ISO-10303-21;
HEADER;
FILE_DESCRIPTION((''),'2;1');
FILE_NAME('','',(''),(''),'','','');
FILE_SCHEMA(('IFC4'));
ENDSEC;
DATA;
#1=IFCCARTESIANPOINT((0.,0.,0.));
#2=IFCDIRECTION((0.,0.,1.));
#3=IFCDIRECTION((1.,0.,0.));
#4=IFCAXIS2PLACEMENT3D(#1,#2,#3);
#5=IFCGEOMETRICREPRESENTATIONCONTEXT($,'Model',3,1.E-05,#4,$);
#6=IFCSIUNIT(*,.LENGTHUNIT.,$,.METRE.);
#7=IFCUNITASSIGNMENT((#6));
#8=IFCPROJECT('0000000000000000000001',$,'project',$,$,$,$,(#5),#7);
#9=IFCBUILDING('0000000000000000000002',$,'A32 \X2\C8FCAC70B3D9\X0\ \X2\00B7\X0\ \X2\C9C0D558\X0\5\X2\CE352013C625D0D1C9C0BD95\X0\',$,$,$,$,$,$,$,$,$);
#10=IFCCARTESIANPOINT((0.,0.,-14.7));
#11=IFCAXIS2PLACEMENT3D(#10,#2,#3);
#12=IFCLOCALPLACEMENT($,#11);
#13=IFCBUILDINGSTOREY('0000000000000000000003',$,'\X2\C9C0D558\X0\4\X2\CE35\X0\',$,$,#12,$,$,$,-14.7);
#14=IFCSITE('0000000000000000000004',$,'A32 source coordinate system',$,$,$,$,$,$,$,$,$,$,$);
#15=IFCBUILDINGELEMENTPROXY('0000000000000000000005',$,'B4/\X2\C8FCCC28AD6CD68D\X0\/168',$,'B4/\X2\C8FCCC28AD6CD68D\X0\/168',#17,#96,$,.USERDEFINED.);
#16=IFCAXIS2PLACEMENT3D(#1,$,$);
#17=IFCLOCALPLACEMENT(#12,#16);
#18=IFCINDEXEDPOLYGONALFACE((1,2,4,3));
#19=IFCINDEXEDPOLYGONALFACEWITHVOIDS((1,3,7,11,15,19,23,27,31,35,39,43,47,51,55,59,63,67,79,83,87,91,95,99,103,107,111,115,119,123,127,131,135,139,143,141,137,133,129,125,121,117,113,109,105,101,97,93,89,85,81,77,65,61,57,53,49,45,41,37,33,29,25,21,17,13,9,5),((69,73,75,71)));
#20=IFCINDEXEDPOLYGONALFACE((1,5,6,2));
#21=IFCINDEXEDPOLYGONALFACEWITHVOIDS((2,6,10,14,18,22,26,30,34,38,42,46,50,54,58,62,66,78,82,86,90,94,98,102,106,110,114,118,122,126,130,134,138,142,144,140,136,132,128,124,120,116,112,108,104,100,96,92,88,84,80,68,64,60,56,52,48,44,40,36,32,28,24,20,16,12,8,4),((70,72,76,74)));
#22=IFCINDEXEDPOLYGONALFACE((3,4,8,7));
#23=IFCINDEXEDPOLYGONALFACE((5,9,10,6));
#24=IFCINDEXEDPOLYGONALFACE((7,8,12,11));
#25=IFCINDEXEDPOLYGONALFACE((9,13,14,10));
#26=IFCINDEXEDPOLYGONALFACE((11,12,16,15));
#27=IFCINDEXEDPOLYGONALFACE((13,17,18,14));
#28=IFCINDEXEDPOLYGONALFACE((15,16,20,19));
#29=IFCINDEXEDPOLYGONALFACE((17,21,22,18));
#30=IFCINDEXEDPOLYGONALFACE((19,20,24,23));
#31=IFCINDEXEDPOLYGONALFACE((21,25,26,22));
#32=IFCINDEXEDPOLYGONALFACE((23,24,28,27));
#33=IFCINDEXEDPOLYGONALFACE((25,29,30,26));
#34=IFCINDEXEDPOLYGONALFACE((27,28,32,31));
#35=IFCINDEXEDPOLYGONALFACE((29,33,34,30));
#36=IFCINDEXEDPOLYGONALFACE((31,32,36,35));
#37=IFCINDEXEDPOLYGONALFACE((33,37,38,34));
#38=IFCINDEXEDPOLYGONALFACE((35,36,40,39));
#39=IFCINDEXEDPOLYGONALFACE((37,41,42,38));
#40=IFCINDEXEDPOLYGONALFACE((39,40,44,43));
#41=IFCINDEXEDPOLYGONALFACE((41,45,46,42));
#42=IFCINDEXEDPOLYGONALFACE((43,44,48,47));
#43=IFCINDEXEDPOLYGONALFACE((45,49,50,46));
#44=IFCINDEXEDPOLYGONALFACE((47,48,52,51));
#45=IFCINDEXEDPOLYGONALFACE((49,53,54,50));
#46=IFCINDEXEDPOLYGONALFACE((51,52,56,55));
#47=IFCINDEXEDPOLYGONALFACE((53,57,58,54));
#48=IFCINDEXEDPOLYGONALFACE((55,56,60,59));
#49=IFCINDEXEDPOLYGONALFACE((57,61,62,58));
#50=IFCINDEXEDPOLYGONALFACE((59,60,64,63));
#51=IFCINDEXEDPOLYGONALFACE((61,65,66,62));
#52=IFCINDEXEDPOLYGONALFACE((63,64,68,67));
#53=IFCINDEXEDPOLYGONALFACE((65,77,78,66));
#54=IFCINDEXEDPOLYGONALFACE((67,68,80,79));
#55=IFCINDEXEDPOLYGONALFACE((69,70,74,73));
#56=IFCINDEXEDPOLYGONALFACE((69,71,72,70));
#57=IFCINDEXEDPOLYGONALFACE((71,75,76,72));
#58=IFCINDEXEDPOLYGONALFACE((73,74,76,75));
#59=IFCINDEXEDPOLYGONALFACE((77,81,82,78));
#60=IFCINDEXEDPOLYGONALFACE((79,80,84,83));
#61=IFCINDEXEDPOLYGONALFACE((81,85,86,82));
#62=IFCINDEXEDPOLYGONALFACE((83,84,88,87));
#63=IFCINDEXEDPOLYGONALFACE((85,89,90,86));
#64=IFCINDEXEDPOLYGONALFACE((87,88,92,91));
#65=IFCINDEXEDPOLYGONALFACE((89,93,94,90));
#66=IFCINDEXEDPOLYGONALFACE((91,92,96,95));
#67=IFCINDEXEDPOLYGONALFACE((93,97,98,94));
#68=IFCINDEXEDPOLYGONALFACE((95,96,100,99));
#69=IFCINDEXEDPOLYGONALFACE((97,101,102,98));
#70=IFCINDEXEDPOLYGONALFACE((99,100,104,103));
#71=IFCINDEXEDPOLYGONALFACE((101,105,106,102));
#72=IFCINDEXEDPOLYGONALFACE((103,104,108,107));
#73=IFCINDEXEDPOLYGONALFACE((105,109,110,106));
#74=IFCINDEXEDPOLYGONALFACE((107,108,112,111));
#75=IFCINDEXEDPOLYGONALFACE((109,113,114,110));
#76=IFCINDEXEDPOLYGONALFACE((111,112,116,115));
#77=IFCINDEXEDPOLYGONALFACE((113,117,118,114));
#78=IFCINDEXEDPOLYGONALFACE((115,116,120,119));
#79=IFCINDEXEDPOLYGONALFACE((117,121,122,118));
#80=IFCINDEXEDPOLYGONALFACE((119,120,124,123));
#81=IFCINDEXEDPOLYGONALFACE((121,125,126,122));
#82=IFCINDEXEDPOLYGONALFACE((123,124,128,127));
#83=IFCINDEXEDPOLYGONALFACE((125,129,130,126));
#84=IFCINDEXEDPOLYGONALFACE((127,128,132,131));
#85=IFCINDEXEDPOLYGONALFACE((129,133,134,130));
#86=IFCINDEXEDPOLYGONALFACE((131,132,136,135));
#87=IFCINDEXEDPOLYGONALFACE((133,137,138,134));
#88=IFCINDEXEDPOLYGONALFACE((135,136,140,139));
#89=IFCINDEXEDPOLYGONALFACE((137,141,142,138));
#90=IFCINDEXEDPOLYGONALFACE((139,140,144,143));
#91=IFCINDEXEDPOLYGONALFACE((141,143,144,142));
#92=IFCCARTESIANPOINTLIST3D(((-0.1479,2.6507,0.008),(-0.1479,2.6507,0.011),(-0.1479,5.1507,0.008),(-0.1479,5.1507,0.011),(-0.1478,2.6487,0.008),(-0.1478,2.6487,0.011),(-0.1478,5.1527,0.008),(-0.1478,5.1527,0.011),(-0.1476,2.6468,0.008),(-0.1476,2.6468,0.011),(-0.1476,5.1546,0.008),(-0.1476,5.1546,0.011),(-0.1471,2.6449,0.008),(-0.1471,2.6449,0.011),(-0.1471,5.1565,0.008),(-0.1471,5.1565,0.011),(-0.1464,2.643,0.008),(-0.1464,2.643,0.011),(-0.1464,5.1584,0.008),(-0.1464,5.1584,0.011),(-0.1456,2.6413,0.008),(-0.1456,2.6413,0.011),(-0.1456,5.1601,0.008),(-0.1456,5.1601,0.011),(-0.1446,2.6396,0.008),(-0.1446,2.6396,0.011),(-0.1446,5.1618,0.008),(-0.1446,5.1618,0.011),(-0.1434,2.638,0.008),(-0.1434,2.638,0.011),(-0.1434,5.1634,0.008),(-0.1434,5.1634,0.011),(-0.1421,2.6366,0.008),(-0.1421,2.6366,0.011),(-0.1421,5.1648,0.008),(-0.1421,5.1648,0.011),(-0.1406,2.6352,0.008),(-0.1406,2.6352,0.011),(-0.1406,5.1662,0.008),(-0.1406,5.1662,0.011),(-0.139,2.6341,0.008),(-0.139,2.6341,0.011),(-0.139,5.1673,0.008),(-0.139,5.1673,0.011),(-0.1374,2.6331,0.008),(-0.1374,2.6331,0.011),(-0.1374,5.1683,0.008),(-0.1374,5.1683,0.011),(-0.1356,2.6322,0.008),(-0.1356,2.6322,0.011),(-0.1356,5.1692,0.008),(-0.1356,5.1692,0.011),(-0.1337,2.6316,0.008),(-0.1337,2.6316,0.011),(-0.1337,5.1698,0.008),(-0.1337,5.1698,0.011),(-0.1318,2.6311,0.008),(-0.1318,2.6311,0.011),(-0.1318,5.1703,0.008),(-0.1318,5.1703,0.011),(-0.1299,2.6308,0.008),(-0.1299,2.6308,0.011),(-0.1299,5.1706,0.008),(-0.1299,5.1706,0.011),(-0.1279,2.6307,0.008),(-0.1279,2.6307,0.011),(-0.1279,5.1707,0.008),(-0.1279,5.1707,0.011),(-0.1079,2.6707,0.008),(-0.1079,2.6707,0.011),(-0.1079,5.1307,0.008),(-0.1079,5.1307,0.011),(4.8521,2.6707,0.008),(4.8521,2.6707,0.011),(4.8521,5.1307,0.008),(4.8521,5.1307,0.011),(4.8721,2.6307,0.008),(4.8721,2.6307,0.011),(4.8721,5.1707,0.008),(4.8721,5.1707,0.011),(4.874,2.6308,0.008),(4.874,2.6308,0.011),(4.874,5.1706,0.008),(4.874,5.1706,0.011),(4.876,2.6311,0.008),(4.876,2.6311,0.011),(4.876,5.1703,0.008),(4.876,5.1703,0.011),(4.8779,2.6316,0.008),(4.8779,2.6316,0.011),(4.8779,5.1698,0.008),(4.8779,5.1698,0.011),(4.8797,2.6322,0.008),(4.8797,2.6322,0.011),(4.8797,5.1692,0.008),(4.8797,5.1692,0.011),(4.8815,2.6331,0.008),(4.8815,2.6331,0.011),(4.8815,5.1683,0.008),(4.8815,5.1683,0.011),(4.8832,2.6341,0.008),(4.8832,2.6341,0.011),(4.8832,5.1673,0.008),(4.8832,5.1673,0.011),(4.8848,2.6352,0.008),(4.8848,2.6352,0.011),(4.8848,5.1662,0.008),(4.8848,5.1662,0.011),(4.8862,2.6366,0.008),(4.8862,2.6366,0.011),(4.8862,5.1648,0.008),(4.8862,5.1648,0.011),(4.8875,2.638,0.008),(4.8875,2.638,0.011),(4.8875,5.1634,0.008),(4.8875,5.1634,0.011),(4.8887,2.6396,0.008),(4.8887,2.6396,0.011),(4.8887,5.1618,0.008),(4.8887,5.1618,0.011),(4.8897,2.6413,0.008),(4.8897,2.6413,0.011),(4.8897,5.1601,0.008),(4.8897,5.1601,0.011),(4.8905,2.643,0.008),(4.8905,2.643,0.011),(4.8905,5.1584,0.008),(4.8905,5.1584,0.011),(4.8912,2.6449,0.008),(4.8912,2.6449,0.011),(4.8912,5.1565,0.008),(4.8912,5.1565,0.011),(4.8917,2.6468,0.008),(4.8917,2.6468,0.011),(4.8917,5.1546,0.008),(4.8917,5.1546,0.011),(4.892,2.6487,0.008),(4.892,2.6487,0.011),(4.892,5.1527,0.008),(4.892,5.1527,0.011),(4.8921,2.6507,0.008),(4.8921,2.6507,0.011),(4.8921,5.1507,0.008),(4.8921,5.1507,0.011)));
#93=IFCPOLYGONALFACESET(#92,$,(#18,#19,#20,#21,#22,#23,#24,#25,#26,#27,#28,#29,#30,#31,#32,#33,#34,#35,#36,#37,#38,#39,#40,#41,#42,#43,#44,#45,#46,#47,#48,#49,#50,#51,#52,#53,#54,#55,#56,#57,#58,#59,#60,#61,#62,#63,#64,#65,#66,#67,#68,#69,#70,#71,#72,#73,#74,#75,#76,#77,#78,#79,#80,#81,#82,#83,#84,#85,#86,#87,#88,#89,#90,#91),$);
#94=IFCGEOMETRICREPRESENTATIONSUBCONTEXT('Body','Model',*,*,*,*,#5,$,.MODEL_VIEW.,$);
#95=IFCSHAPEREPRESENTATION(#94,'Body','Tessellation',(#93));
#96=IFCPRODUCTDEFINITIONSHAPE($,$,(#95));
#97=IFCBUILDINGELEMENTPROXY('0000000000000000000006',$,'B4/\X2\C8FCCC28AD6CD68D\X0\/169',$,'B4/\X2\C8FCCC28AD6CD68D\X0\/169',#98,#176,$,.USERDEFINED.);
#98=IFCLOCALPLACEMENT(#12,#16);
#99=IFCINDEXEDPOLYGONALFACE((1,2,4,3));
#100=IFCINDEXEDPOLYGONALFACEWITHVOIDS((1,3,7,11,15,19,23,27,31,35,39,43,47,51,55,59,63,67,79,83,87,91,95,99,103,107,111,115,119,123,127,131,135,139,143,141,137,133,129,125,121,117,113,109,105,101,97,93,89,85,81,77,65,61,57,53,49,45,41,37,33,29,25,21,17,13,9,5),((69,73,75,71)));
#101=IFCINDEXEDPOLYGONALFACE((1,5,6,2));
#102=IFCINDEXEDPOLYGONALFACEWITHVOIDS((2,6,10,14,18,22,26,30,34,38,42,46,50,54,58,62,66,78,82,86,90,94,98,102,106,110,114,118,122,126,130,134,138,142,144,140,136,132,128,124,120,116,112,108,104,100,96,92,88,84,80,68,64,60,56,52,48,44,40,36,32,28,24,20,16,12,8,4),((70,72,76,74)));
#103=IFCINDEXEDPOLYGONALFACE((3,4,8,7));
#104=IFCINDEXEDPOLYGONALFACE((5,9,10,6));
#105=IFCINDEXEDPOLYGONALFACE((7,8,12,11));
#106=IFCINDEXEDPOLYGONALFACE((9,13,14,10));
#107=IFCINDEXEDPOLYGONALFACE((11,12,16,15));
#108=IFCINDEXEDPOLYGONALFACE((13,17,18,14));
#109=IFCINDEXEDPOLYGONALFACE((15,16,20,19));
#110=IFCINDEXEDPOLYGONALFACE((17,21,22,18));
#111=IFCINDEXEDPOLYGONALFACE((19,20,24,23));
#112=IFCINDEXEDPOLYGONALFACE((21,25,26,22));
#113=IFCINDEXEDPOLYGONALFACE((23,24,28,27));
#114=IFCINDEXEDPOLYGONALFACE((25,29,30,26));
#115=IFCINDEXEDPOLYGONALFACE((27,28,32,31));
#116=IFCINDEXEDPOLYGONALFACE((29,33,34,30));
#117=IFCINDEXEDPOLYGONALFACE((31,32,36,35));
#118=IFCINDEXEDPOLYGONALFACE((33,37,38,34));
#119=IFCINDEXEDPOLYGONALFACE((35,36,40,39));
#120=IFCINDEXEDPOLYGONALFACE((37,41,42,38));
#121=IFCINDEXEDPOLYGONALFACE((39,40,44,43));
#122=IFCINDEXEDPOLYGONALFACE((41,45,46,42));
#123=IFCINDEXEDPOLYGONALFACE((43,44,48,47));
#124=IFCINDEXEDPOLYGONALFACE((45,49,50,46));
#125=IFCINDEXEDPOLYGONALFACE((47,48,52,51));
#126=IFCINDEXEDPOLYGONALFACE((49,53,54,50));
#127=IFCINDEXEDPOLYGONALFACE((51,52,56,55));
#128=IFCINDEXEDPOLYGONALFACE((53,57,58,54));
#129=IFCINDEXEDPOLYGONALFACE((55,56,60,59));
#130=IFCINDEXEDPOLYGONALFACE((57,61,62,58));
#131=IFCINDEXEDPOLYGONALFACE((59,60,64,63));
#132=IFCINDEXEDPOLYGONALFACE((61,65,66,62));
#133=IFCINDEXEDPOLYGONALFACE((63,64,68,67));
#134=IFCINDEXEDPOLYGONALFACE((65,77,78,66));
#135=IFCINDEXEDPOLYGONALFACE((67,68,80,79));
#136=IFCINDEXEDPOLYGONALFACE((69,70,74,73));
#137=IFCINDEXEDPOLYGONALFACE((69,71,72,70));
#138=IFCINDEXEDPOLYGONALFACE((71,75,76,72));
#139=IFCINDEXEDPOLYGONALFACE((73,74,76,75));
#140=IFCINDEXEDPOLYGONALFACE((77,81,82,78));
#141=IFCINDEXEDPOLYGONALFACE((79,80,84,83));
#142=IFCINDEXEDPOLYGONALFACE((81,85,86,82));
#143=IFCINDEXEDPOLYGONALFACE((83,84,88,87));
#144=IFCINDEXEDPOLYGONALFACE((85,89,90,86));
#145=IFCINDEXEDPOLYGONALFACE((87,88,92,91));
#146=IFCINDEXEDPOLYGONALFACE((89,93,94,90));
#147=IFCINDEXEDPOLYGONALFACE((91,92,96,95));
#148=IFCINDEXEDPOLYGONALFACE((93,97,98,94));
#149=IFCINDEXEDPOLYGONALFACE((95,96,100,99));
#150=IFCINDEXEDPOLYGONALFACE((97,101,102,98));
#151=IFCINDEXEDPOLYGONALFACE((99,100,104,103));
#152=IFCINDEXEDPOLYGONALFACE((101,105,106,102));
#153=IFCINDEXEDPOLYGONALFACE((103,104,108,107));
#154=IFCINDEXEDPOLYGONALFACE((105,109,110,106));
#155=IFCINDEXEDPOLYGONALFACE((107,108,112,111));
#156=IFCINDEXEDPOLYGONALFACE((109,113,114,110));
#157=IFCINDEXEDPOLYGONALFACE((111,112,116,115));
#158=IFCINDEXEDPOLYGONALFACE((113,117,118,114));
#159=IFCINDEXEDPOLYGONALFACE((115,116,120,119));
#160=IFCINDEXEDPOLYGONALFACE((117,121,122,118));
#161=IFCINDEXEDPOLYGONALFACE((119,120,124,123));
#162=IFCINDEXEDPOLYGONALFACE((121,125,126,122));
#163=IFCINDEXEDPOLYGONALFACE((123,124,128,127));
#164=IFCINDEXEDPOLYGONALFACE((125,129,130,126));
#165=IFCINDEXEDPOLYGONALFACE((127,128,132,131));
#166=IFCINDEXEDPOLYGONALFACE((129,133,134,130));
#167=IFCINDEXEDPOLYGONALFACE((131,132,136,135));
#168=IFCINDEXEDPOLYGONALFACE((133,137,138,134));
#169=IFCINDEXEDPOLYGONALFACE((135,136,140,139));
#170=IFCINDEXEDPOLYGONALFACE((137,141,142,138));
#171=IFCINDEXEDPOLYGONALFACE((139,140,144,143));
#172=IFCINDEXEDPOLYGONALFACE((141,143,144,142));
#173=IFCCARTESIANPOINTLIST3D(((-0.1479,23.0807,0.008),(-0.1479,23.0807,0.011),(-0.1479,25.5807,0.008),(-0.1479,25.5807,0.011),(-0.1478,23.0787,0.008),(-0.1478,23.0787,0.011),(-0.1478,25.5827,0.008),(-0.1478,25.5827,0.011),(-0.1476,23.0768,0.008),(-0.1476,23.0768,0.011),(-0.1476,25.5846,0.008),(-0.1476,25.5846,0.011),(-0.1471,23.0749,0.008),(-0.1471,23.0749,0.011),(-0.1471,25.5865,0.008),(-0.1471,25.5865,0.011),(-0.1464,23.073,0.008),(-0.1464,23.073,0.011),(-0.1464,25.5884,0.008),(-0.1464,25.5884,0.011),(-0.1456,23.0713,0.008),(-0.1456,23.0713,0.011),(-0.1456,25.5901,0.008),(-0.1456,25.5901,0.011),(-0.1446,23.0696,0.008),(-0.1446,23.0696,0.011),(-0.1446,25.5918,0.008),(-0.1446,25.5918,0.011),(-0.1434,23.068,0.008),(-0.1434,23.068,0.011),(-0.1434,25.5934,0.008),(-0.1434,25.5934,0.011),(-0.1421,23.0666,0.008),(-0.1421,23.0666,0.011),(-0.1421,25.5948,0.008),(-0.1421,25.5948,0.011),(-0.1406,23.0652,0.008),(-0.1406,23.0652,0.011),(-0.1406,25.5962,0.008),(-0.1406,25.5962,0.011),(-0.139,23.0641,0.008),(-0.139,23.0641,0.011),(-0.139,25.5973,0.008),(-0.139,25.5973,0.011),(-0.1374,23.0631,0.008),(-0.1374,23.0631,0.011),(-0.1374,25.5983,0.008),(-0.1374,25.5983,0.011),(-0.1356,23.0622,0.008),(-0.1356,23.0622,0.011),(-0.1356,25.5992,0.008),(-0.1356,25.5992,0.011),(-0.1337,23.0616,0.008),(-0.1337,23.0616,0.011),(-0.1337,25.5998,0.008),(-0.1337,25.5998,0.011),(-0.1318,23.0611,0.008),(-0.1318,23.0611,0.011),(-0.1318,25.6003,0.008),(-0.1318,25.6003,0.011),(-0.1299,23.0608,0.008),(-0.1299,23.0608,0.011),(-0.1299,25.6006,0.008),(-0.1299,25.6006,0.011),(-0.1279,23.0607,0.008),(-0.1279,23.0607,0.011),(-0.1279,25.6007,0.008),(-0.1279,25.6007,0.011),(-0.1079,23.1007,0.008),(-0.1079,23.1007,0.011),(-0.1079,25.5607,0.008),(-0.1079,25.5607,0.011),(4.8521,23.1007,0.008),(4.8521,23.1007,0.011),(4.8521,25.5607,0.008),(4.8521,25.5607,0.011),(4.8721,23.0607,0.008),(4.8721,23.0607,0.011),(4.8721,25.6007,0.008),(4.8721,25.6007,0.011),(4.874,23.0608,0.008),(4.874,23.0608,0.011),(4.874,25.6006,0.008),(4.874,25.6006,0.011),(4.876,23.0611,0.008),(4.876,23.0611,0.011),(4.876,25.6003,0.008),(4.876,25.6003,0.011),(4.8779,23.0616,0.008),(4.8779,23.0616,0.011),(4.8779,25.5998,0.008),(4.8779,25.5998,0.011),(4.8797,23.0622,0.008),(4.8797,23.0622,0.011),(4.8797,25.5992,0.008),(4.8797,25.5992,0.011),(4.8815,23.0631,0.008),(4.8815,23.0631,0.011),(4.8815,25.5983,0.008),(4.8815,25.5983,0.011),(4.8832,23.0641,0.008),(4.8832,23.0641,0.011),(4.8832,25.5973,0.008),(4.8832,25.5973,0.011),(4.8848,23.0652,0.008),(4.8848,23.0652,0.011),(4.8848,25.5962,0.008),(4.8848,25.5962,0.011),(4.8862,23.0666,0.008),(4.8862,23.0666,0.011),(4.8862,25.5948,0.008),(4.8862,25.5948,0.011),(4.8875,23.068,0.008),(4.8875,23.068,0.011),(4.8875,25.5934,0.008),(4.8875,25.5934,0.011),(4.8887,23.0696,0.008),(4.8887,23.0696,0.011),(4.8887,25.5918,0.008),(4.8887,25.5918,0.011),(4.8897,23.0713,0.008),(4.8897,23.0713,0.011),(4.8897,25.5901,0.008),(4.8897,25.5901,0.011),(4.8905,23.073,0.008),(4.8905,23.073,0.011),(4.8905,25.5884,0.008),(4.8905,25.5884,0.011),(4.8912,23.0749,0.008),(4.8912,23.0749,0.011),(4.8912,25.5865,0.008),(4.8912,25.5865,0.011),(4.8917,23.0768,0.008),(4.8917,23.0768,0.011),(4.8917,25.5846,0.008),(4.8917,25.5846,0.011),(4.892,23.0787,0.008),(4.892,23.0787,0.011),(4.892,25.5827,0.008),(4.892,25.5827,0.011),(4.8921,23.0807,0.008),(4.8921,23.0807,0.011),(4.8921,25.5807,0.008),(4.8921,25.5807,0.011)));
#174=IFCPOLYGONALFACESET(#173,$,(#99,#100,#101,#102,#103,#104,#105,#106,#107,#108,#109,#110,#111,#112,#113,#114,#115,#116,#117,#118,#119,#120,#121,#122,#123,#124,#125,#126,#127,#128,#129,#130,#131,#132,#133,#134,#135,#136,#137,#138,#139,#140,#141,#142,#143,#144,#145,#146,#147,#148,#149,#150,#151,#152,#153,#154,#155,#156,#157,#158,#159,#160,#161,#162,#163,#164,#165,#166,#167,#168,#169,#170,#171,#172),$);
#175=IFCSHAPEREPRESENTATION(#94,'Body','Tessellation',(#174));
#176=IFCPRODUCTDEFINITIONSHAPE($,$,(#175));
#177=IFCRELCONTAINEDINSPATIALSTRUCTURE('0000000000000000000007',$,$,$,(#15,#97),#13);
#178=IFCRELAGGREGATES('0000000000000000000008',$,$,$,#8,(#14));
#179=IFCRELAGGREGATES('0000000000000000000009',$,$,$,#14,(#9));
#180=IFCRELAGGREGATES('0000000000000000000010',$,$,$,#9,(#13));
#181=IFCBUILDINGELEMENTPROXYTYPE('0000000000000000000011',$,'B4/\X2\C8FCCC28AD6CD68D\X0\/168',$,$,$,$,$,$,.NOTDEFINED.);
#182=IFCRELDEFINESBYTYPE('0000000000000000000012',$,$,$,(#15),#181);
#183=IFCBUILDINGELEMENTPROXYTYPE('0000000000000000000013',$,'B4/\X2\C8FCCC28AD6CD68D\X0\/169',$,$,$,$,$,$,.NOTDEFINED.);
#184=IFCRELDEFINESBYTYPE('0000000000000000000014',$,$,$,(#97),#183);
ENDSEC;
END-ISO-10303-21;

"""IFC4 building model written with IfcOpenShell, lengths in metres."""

from ifc_helpers import new_model, si_unit, frame, origin, origin_with_axes, place, context, subcontext, project, spatial, polyline, outline, extrude, source, transform, mapped, type_object, type_shapes, element, save


model = new_model("IFC4")

# Units and contexts
model_context = context("Model", 3, precision=1e-05, world=origin_with_axes())
body_context = subcontext(model_context, "Body", "Model", "MODEL_VIEW")
ifc_project = project(units=[si_unit("LENGTHUNIT", "METRE")], contexts=[model_context])

# Site, building, storey
site = spatial("IfcSite", under=ifc_project, Name="A32 source coordinate system")
building = spatial("IfcBuilding", under=site, Name="A32 주거동 · 지하5층–옥탑지붕")
storey_placement = place(None, frame((0.0, 0.0, -14.7), z_axis=(0.0, 0.0, 1.0), x_axis=(1.0, 0.0, 0.0)))
storey = spatial("IfcBuildingStorey", under=building, at=storey_placement, Name="지하4층", Elevation=-14.7)

# Building element proxies
building_element_proxy_type_1 = type_object("IfcBuildingElementProxyType", Name="B4/주차구획/168", PredefinedType="NOTDEFINED")
shared_shape_1 = source(origin(), body_context, "Body", "SweptSolid", [
    extrude(outline(polyline([(-0.1279, 2.6307), (-0.1299, 2.6308), (-0.1318, 2.6311), (-0.1337, 2.6316), (-0.1356, 2.6322), (-0.1374, 2.6331), (-0.139, 2.6341), (-0.1406, 2.6352), (-0.1421, 2.6366), (-0.1434, 2.638), (-0.1446, 2.6396), (-0.1456, 2.6413), (-0.1464, 2.643), (-0.1471, 2.6449), (-0.1476, 2.6468), (-0.1478, 2.6487), (-0.1479, 2.6507), (-0.1479, 5.1507), (-0.1478, 5.1527), (-0.1476, 5.1546), (-0.1471, 5.1565), (-0.1464, 5.1584), (-0.1456, 5.1601), (-0.1446, 5.1618), (-0.1434, 5.1634), (-0.1421, 5.1648), (-0.1406, 5.1662), (-0.139, 5.1673), (-0.1374, 5.1683), (-0.1356, 5.1692), (-0.1337, 5.1698), (-0.1318, 5.1703), (-0.1299, 5.1706), (-0.1279, 5.1707), (4.8721, 5.1707), (4.874, 5.1706), (4.876, 5.1703), (4.8779, 5.1698), (4.8797, 5.1692), (4.8815, 5.1683), (4.8832, 5.1673), (4.8848, 5.1662), (4.8862, 5.1648), (4.8875, 5.1634), (4.8887, 5.1618), (4.8897, 5.1601), (4.8905, 5.1584), (4.8912, 5.1565), (4.8917, 5.1546), (4.892, 5.1527), (4.8921, 5.1507), (4.8921, 2.6507), (4.892, 2.6487), (4.8917, 2.6468), (4.8912, 2.6449), (4.8905, 2.643), (4.8897, 2.6413), (4.8887, 2.6396), (4.8875, 2.638), (4.8862, 2.6366), (4.8848, 2.6352), (4.8832, 2.6341), (4.8815, 2.6331), (4.8797, 2.6322), (4.8779, 2.6316), (4.876, 2.6311), (4.874, 2.6308), (4.8721, 2.6307), (-0.1279, 2.6307)]), holes=[polyline([(-0.1079, 2.6707), (4.8521, 2.6707), (4.8521, 5.1307), (-0.1079, 5.1307), (-0.1079, 2.6707)])]), frame((0.0, 0.0, 0.008)), (0.0, 0.0, 1.0), 0.003),
])
type_shapes(building_element_proxy_type_1, [shared_shape_1])
proxy_1_placement = place(storey_placement, origin_with_axes())
element("IfcBuildingElementProxy", 1, at=proxy_1_placement, inside=storey, type_object=building_element_proxy_type_1, Name="B4/주차구획/168", ObjectType="B4/주차구획/168", PredefinedType="USERDEFINED", context=body_context, shape_type="MappedRepresentation", body=[
    mapped(shared_shape_1, transform((0.0, 0.0, 0.0), scale=1.0)),
])
building_element_proxy_type_2 = type_object("IfcBuildingElementProxyType", Name="B4/주차구획/169", PredefinedType="NOTDEFINED")
shared_shape_2 = source(origin(), body_context, "Body", "SweptSolid", [
    extrude(outline(polyline([(-0.1279, 23.0607), (-0.1299, 23.0608), (-0.1318, 23.0611), (-0.1337, 23.0616), (-0.1356, 23.0622), (-0.1374, 23.0631), (-0.139, 23.0641), (-0.1406, 23.0652), (-0.1421, 23.0666), (-0.1434, 23.068), (-0.1446, 23.0696), (-0.1456, 23.0713), (-0.1464, 23.073), (-0.1471, 23.0749), (-0.1476, 23.0768), (-0.1478, 23.0787), (-0.1479, 23.0807), (-0.1479, 25.5807), (-0.1478, 25.5827), (-0.1476, 25.5846), (-0.1471, 25.5865), (-0.1464, 25.5884), (-0.1456, 25.5901), (-0.1446, 25.5918), (-0.1434, 25.5934), (-0.1421, 25.5948), (-0.1406, 25.5962), (-0.139, 25.5973), (-0.1374, 25.5983), (-0.1356, 25.5992), (-0.1337, 25.5998), (-0.1318, 25.6003), (-0.1299, 25.6006), (-0.1279, 25.6007), (4.8721, 25.6007), (4.874, 25.6006), (4.876, 25.6003), (4.8779, 25.5998), (4.8797, 25.5992), (4.8815, 25.5983), (4.8832, 25.5973), (4.8848, 25.5962), (4.8862, 25.5948), (4.8875, 25.5934), (4.8887, 25.5918), (4.8897, 25.5901), (4.8905, 25.5884), (4.8912, 25.5865), (4.8917, 25.5846), (4.892, 25.5827), (4.8921, 25.5807), (4.8921, 23.0807), (4.892, 23.0787), (4.8917, 23.0768), (4.8912, 23.0749), (4.8905, 23.073), (4.8897, 23.0713), (4.8887, 23.0696), (4.8875, 23.068), (4.8862, 23.0666), (4.8848, 23.0652), (4.8832, 23.0641), (4.8815, 23.0631), (4.8797, 23.0622), (4.8779, 23.0616), (4.876, 23.0611), (4.874, 23.0608), (4.8721, 23.0607), (-0.1279, 23.0607)]), holes=[polyline([(-0.1079, 23.1007), (4.8521, 23.1007), (4.8521, 25.5607), (-0.1079, 25.5607), (-0.1079, 23.1007)])]), frame((0.0, 0.0, 0.008)), (0.0, 0.0, 1.0), 0.003),
])
type_shapes(building_element_proxy_type_2, [shared_shape_2])
proxy_2_placement = place(storey_placement, origin_with_axes())
element("IfcBuildingElementProxy", 2, at=proxy_2_placement, inside=storey, type_object=building_element_proxy_type_2, Name="B4/주차구획/169", ObjectType="B4/주차구획/169", PredefinedType="USERDEFINED", context=body_context, shape_type="MappedRepresentation", body=[
    mapped(shared_shape_2, transform((0.0, 0.0, 0.0), scale=1.0)),
])

save(model, "model.ifc")
